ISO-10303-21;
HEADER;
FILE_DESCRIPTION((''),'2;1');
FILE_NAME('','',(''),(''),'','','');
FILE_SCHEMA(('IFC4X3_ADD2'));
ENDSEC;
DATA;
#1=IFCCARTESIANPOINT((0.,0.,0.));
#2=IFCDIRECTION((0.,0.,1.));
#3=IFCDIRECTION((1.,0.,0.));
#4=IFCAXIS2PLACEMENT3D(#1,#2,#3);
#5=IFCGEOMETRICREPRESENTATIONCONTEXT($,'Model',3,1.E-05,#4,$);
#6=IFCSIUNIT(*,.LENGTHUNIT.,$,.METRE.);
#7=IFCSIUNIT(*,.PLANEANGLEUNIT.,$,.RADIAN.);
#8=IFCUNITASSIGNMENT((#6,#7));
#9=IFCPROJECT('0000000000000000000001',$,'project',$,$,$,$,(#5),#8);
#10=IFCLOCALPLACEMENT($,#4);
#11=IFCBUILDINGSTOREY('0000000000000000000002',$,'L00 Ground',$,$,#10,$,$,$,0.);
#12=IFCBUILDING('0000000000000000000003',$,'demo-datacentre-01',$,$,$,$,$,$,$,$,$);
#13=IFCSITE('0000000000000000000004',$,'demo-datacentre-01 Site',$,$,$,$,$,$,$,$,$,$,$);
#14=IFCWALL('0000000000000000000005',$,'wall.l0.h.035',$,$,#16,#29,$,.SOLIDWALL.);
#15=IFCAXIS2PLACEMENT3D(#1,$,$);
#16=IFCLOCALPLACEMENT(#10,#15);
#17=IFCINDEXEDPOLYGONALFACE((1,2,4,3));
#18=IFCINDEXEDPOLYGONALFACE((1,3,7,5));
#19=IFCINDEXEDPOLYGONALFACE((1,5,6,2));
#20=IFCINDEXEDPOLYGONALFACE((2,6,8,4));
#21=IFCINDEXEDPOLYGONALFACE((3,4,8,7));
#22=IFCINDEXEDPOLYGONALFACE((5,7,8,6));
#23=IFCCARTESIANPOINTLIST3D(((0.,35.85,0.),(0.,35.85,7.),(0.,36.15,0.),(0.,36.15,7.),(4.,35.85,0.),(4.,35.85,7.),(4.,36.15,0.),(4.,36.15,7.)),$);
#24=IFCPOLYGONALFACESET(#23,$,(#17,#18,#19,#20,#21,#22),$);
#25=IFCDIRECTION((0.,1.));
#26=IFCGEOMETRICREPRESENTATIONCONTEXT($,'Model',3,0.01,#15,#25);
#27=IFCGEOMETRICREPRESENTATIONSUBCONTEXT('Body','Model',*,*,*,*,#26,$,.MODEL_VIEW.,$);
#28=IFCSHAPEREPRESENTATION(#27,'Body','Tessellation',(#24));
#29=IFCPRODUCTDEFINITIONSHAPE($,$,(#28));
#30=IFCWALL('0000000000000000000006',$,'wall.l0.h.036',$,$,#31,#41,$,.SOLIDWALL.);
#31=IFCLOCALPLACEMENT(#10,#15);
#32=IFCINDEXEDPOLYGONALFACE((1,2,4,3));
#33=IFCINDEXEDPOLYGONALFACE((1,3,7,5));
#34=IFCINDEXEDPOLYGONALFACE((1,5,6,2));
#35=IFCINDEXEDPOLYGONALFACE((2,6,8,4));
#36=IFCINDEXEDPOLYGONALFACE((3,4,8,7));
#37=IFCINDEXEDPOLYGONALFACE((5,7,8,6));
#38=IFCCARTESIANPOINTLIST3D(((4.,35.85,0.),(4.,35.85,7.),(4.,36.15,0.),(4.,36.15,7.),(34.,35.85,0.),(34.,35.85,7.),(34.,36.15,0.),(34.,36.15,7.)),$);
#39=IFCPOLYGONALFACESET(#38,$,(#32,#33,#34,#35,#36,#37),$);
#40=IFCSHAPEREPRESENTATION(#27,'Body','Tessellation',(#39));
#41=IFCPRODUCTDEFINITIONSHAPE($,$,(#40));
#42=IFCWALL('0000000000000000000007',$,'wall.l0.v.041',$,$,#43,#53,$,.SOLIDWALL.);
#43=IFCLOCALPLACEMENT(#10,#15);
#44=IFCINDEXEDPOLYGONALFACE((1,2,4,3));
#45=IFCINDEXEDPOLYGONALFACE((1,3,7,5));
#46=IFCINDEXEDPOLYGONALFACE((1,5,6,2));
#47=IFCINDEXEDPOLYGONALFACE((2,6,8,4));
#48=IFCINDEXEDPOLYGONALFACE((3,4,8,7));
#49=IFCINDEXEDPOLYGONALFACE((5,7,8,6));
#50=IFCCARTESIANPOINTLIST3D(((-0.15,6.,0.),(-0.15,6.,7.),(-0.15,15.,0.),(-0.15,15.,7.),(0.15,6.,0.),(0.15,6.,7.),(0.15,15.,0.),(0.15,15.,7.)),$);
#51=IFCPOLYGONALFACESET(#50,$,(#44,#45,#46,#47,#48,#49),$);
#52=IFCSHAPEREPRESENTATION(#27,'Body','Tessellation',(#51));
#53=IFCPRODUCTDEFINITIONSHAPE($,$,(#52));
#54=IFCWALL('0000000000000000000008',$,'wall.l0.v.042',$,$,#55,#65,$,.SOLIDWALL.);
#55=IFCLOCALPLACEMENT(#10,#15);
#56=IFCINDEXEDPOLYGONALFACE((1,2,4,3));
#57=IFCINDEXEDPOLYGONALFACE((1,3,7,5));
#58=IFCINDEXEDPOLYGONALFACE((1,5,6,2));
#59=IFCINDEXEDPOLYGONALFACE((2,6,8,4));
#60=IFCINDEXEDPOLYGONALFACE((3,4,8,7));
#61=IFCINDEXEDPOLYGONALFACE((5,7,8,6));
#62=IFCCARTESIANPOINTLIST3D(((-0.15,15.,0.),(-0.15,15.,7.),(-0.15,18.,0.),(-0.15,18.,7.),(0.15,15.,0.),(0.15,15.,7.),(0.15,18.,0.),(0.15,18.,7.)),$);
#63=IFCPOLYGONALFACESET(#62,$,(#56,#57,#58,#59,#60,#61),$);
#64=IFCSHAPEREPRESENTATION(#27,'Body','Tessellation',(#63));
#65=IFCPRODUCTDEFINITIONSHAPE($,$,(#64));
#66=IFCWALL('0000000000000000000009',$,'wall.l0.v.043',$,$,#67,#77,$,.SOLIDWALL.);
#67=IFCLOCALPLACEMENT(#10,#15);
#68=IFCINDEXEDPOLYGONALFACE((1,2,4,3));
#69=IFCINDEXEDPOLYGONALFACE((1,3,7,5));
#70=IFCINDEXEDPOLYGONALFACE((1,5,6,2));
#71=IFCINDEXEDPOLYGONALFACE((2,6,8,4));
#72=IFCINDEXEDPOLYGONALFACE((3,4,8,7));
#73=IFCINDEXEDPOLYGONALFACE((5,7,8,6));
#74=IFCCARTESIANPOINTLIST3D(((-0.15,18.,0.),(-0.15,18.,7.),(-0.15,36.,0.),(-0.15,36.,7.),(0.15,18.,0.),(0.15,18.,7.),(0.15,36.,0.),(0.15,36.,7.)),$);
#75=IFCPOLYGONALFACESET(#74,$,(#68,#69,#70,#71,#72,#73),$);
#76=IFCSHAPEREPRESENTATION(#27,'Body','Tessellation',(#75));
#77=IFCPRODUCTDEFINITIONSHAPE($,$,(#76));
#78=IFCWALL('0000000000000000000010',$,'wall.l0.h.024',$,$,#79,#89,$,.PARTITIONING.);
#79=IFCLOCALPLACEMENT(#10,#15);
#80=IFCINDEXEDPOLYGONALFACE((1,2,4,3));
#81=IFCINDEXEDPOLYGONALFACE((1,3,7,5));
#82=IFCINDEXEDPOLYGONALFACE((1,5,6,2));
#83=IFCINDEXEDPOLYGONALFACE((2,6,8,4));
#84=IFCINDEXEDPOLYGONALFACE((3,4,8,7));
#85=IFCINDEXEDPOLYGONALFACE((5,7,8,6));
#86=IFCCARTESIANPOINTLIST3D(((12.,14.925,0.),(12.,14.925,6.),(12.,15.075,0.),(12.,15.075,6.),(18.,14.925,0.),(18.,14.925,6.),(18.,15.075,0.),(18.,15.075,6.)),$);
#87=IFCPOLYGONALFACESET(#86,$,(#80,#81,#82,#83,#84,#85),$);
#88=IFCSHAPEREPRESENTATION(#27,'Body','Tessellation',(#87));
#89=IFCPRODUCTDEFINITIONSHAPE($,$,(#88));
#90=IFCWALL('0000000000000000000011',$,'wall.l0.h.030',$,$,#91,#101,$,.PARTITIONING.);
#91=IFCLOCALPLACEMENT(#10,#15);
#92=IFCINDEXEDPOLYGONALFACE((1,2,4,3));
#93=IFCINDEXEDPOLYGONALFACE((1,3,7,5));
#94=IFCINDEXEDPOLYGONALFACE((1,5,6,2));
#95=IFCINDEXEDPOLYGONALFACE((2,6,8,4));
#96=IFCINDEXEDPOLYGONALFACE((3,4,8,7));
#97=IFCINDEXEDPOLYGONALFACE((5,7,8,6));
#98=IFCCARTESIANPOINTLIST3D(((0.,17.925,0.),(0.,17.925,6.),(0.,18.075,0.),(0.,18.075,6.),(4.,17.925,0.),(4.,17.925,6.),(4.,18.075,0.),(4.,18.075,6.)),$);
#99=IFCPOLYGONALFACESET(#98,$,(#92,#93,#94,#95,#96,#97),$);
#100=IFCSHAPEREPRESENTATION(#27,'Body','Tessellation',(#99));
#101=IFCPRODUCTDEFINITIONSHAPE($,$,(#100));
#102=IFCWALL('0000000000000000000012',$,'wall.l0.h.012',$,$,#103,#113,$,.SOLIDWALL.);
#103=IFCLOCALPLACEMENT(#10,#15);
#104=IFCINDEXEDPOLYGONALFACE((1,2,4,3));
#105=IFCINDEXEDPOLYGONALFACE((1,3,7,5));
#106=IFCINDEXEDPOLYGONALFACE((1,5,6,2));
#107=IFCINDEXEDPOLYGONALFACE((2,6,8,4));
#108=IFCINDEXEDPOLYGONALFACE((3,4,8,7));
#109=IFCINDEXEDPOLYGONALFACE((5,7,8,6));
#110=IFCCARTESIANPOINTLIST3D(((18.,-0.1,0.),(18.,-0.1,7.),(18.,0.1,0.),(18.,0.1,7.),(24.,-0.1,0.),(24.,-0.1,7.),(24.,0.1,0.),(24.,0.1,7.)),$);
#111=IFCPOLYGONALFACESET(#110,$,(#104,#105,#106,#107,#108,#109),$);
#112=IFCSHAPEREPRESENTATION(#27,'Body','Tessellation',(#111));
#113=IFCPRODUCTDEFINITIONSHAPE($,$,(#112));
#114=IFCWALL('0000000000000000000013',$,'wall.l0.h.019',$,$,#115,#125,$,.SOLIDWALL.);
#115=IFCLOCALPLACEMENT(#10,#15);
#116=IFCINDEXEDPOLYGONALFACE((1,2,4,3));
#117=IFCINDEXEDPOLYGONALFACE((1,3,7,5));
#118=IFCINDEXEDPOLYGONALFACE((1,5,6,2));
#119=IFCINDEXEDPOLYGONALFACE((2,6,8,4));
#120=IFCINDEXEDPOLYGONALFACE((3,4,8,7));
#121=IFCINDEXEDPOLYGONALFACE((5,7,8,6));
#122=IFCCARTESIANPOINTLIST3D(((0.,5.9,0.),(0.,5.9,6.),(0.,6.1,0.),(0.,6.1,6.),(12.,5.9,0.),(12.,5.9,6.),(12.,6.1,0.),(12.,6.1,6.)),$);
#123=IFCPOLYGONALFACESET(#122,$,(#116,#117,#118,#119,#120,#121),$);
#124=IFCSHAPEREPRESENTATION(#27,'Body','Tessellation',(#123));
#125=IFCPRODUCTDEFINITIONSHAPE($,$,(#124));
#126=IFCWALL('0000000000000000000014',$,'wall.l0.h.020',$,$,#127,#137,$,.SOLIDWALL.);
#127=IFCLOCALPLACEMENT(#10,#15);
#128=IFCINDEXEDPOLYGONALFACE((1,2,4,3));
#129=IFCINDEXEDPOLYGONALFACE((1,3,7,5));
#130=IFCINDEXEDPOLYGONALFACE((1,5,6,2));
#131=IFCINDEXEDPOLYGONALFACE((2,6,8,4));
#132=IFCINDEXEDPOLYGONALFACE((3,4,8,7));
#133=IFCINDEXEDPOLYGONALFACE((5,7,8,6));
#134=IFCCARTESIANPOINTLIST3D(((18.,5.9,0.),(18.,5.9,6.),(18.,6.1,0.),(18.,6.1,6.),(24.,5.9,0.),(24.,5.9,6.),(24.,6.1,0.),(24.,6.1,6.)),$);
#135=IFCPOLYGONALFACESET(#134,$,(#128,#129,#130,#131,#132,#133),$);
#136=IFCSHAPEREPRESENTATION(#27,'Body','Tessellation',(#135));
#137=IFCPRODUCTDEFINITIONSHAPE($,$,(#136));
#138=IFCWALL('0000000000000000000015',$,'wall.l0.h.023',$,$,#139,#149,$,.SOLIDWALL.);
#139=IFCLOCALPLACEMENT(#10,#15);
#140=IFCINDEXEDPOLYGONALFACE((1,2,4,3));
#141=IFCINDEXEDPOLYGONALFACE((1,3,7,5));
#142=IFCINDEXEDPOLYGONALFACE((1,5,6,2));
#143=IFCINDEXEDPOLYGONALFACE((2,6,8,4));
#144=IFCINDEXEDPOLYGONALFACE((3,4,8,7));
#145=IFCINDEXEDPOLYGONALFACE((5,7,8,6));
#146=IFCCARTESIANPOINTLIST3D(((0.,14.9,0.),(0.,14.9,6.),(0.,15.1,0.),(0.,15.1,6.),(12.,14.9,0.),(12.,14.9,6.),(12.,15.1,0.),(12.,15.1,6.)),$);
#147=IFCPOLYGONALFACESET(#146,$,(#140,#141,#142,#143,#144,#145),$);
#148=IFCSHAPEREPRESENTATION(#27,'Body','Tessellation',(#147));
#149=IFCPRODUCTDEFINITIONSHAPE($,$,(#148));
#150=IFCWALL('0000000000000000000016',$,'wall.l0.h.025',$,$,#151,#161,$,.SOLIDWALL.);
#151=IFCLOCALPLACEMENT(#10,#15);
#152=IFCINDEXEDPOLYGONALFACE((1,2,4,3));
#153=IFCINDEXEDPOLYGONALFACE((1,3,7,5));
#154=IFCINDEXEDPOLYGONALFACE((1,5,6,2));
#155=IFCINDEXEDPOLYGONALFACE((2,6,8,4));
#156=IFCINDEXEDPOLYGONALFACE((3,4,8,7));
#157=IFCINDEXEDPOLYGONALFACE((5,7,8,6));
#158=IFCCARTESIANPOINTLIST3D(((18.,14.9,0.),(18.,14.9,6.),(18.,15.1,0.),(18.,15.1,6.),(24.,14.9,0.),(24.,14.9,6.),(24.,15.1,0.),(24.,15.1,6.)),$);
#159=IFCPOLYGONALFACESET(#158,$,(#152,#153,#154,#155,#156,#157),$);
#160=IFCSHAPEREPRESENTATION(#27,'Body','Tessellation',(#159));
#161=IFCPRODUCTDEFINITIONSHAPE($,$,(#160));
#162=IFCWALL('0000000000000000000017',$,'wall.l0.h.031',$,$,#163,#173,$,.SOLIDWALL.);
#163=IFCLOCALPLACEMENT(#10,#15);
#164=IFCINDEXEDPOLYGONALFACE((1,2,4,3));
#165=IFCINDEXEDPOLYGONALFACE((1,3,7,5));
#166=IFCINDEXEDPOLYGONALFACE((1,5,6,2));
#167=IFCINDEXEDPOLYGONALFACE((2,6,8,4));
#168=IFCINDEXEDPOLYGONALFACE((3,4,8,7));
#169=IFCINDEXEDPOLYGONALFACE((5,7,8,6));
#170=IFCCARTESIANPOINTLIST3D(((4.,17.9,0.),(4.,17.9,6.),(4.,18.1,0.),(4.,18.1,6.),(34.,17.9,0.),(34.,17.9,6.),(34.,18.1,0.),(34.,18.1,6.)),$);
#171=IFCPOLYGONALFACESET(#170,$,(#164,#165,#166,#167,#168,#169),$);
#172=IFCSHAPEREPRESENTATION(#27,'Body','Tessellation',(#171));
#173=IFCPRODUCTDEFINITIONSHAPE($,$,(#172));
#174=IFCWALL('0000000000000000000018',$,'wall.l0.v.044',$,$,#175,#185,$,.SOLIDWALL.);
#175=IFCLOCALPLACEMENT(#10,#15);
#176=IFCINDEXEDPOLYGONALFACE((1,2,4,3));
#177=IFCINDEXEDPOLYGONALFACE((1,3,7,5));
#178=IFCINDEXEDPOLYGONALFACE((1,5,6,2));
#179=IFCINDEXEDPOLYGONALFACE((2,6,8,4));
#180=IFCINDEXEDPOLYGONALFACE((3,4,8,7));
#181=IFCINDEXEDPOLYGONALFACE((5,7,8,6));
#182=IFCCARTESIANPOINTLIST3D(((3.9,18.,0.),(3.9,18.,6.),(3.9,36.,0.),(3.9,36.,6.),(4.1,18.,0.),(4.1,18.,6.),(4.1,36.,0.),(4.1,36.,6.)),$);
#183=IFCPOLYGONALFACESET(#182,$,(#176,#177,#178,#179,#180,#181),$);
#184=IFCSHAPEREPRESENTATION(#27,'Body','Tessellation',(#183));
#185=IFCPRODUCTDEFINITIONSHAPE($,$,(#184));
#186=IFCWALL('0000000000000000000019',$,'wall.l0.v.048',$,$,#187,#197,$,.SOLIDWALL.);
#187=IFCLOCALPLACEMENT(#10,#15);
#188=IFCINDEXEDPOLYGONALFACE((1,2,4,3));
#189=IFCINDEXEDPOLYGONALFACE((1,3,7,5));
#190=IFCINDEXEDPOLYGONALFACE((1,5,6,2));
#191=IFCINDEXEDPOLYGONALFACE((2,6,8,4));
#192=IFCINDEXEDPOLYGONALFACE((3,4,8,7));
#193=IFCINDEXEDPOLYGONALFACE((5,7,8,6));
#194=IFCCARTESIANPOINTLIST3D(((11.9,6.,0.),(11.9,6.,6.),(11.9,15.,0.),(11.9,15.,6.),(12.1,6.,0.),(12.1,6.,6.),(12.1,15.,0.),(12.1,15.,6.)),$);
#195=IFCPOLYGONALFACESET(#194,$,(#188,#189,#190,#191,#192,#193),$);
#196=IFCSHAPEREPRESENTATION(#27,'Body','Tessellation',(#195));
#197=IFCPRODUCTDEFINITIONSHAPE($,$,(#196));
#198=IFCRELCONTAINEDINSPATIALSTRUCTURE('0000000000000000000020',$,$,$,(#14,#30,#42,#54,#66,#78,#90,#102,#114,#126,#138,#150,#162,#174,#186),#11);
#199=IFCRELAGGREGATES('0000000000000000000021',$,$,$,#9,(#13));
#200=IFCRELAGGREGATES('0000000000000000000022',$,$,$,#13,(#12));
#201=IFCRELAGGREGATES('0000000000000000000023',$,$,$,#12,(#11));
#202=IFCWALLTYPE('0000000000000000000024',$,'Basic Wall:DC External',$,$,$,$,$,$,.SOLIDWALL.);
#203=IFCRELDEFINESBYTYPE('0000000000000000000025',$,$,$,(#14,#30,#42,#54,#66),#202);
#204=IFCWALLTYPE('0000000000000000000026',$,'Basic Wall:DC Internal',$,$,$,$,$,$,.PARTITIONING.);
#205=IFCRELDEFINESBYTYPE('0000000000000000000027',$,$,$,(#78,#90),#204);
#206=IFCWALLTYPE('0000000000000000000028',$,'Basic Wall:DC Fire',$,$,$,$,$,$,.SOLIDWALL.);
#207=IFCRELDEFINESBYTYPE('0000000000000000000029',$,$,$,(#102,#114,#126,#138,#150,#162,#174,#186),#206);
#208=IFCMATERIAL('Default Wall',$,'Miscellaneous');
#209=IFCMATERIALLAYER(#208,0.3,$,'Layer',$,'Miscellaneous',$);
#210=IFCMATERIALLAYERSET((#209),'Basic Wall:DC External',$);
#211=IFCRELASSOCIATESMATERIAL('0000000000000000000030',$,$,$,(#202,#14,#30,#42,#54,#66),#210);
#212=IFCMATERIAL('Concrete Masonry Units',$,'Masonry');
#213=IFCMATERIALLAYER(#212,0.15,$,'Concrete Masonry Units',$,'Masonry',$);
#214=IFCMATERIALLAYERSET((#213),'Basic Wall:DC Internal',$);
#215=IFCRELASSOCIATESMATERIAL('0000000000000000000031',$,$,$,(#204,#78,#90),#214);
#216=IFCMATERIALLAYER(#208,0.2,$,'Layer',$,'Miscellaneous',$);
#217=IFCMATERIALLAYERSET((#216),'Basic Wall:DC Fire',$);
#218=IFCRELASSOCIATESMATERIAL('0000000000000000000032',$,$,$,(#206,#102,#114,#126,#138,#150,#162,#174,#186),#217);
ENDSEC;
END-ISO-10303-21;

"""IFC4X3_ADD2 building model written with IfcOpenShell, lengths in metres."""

from ifc_helpers import new_model, si_unit, direction, frame, frame_2d, origin, origin_with_axes, place, context, subcontext, project, spatial, rectangle, extrude, material, layer, layer_set, type_object, element, save


model = new_model("IFC4X3_ADD2")

# Units and contexts
model_context_1 = context("Model", 3, precision=0.01, world=origin(), true_north=direction((0.0, 1.0)))
model_context_2 = context("Model", 3, precision=1e-05, world=origin_with_axes())
body_context = subcontext(model_context_1, "Body", "Model", "MODEL_VIEW")
ifc_project = project(units=[si_unit("LENGTHUNIT", "METRE"), si_unit("PLANEANGLEUNIT", "RADIAN")], contexts=[model_context_2])

# Site, building, storey
site = spatial("IfcSite", under=ifc_project, Name="demo-datacentre-01 Site")
building = spatial("IfcBuilding", under=site, Name="demo-datacentre-01")
storey_placement = place(None, origin_with_axes())
storey = spatial("IfcBuildingStorey", under=building, at=storey_placement, Name="L00 Ground", Elevation=0.0)

# Walls
ifc_material_1 = material(Name="Default Wall", Category="Miscellaneous")
ifc_layer_1 = layer(ifc_material_1, 0.3, Name="Layer", Category="Miscellaneous")
ifc_layer_set_1 = layer_set([ifc_layer_1], Name="Basic Wall:DC External")
wall_type_1 = type_object("IfcWallType", Name="Basic Wall:DC External", PredefinedType="SOLIDWALL", material=ifc_layer_set_1)
placement_1 = place(None, origin())
placement_2 = place(placement_1, origin())
placement_3 = place(placement_2, origin())
wall_1_placement = place(placement_3, frame((0.0, 36.0, 0.0)))
element("IfcWall", 1, at=wall_1_placement, inside=storey, type_object=wall_type_1, material=ifc_layer_set_1, Name="wall.l0.h.035", PredefinedType="SOLIDWALL", context=body_context, shape_type="SweptSolid", body=[
    extrude(rectangle(XDim=4.0, YDim=0.3, at=frame_2d((2.0, 0.0), x_axis=(-1.0, 0.0))), origin(), (0.0, 0.0, 1.0), 7.0),
])
wall_2_placement = place(placement_3, frame((4.0, 36.0, 0.0)))
element("IfcWall", 2, at=wall_2_placement, inside=storey, type_object=wall_type_1, material=ifc_layer_set_1, Name="wall.l0.h.036", PredefinedType="SOLIDWALL", context=body_context, shape_type="SweptSolid", body=[
    extrude(rectangle(XDim=30.0, YDim=0.3, at=frame_2d((15.0, 0.0), x_axis=(-1.0, 0.0))), origin(), (0.0, 0.0, 1.0), 7.0),
])
wall_3_placement = place(placement_3, frame((0.0, 6.0, 0.0), z_axis=(0.0, 0.0, 1.0), x_axis=(0.0, 1.0, 0.0)))
element("IfcWall", 3, at=wall_3_placement, inside=storey, type_object=wall_type_1, material=ifc_layer_set_1, Name="wall.l0.v.041", PredefinedType="SOLIDWALL", context=body_context, shape_type="SweptSolid", body=[
    extrude(rectangle(XDim=9.0, YDim=0.3, at=frame_2d((4.5, 0.0), x_axis=(-1.0, 0.0))), origin(), (0.0, 0.0, 1.0), 7.0),
])
wall_4_placement = place(placement_3, frame((0.0, 15.0, 0.0), z_axis=(0.0, 0.0, 1.0), x_axis=(0.0, 1.0, 0.0)))
element("IfcWall", 4, at=wall_4_placement, inside=storey, type_object=wall_type_1, material=ifc_layer_set_1, Name="wall.l0.v.042", PredefinedType="SOLIDWALL", context=body_context, shape_type="SweptSolid", body=[
    extrude(rectangle(XDim=3.0, YDim=0.3, at=frame_2d((1.5, 0.0), x_axis=(-1.0, 0.0))), origin(), (0.0, 0.0, 1.0), 7.0),
])
wall_5_placement = place(placement_3, frame((0.0, 18.0, 0.0), z_axis=(0.0, 0.0, 1.0), x_axis=(0.0, 1.0, 0.0)))
element("IfcWall", 5, at=wall_5_placement, inside=storey, type_object=wall_type_1, material=ifc_layer_set_1, Name="wall.l0.v.043", PredefinedType="SOLIDWALL", context=body_context, shape_type="SweptSolid", body=[
    extrude(rectangle(XDim=18.0, YDim=0.3, at=frame_2d((9.0, 0.0), x_axis=(-1.0, 0.0))), origin(), (0.0, 0.0, 1.0), 7.0),
])
ifc_material_2 = material(Name="Concrete Masonry Units", Category="Masonry")
ifc_layer_2 = layer(ifc_material_2, 0.15, Name="Concrete Masonry Units", Category="Masonry")
ifc_layer_set_2 = layer_set([ifc_layer_2], Name="Basic Wall:DC Internal")
wall_type_2 = type_object("IfcWallType", Name="Basic Wall:DC Internal", PredefinedType="PARTITIONING", material=ifc_layer_set_2)
wall_6_placement = place(placement_3, frame((12.0, 15.0, 0.0)))
element("IfcWall", 6, at=wall_6_placement, inside=storey, type_object=wall_type_2, material=ifc_layer_set_2, Name="wall.l0.h.024", PredefinedType="PARTITIONING", context=body_context, shape_type="SweptSolid", body=[
    extrude(rectangle(XDim=6.0, YDim=0.15, at=frame_2d((3.0, 0.0), x_axis=(-1.0, 0.0))), origin(), (0.0, 0.0, 1.0), 6.0),
])
wall_7_placement = place(placement_3, frame((0.0, 18.0, 0.0)))
element("IfcWall", 7, at=wall_7_placement, inside=storey, type_object=wall_type_2, material=ifc_layer_set_2, Name="wall.l0.h.030", PredefinedType="PARTITIONING", context=body_context, shape_type="SweptSolid", body=[
    extrude(rectangle(XDim=4.0, YDim=0.15, at=frame_2d((2.0, 0.0), x_axis=(-1.0, 0.0))), origin(), (0.0, 0.0, 1.0), 6.0),
])
ifc_layer_3 = layer(ifc_material_1, 0.2, Name="Layer", Category="Miscellaneous")
ifc_layer_set_3 = layer_set([ifc_layer_3], Name="Basic Wall:DC Fire")
wall_type_3 = type_object("IfcWallType", Name="Basic Wall:DC Fire", PredefinedType="SOLIDWALL", material=ifc_layer_set_3)
wall_8_placement = place(placement_3, frame((18.0, 0.0, 0.0)))
element("IfcWall", 8, at=wall_8_placement, inside=storey, type_object=wall_type_3, material=ifc_layer_set_3, Name="wall.l0.h.012", PredefinedType="SOLIDWALL", context=body_context, shape_type="SweptSolid", body=[
    extrude(rectangle(XDim=6.0, YDim=0.2, at=frame_2d((3.0, 0.0), x_axis=(-1.0, 0.0))), origin(), (0.0, 0.0, 1.0), 7.0),
])
wall_9_placement = place(placement_3, frame((0.0, 6.0, 0.0)))
element("IfcWall", 9, at=wall_9_placement, inside=storey, type_object=wall_type_3, material=ifc_layer_set_3, Name="wall.l0.h.019", PredefinedType="SOLIDWALL", context=body_context, shape_type="SweptSolid", body=[
    extrude(rectangle(XDim=12.0, YDim=0.2, at=frame_2d((6.0, 0.0), x_axis=(-1.0, 0.0))), origin(), (0.0, 0.0, 1.0), 6.0),
])
wall_10_placement = place(placement_3, frame((18.0, 6.0, 0.0)))
element("IfcWall", 10, at=wall_10_placement, inside=storey, type_object=wall_type_3, material=ifc_layer_set_3, Name="wall.l0.h.020", PredefinedType="SOLIDWALL", context=body_context, shape_type="SweptSolid", body=[
    extrude(rectangle(XDim=6.0, YDim=0.2, at=frame_2d((3.0, 0.0), x_axis=(-1.0, 0.0))), origin(), (0.0, 0.0, 1.0), 6.0),
])
wall_11_placement = place(placement_3, frame((0.0, 15.0, 0.0)))
element("IfcWall", 11, at=wall_11_placement, inside=storey, type_object=wall_type_3, material=ifc_layer_set_3, Name="wall.l0.h.023", PredefinedType="SOLIDWALL", context=body_context, shape_type="SweptSolid", body=[
    extrude(rectangle(XDim=12.0, YDim=0.2, at=frame_2d((6.0, 0.0), x_axis=(-1.0, 0.0))), origin(), (0.0, 0.0, 1.0), 6.0),
])
wall_12_placement = place(placement_3, frame((18.0, 15.0, 0.0)))
element("IfcWall", 12, at=wall_12_placement, inside=storey, type_object=wall_type_3, material=ifc_layer_set_3, Name="wall.l0.h.025", PredefinedType="SOLIDWALL", context=body_context, shape_type="SweptSolid", body=[
    extrude(rectangle(XDim=6.0, YDim=0.2, at=frame_2d((3.0, 0.0), x_axis=(-1.0, 0.0))), origin(), (0.0, 0.0, 1.0), 6.0),
])
wall_13_placement = place(placement_3, frame((4.0, 18.0, 0.0)))
element("IfcWall", 13, at=wall_13_placement, inside=storey, type_object=wall_type_3, material=ifc_layer_set_3, Name="wall.l0.h.031", PredefinedType="SOLIDWALL", context=body_context, shape_type="SweptSolid", body=[
    extrude(rectangle(XDim=30.0, YDim=0.2, at=frame_2d((15.0, 0.0), x_axis=(-1.0, 0.0))), origin(), (0.0, 0.0, 1.0), 6.0),
])
wall_14_placement = place(placement_3, frame((4.0, 18.0, 0.0), z_axis=(0.0, 0.0, 1.0), x_axis=(0.0, 1.0, 0.0)))
element("IfcWall", 14, at=wall_14_placement, inside=storey, type_object=wall_type_3, material=ifc_layer_set_3, Name="wall.l0.v.044", PredefinedType="SOLIDWALL", context=body_context, shape_type="SweptSolid", body=[
    extrude(rectangle(XDim=18.0, YDim=0.2, at=frame_2d((9.0, 0.0), x_axis=(-1.0, 0.0))), origin(), (0.0, 0.0, 1.0), 6.0),
])
wall_15_placement = place(placement_3, frame((12.0, 6.0, 0.0), z_axis=(0.0, 0.0, 1.0), x_axis=(0.0, 1.0, 0.0)))
element("IfcWall", 15, at=wall_15_placement, inside=storey, type_object=wall_type_3, material=ifc_layer_set_3, Name="wall.l0.v.048", PredefinedType="SOLIDWALL", context=body_context, shape_type="SweptSolid", body=[
    extrude(rectangle(XDim=9.0, YDim=0.2, at=frame_2d((4.5, 0.0), x_axis=(-1.0, 0.0))), origin(), (0.0, 0.0, 1.0), 6.0),
])

save(model, "model.ifc")
